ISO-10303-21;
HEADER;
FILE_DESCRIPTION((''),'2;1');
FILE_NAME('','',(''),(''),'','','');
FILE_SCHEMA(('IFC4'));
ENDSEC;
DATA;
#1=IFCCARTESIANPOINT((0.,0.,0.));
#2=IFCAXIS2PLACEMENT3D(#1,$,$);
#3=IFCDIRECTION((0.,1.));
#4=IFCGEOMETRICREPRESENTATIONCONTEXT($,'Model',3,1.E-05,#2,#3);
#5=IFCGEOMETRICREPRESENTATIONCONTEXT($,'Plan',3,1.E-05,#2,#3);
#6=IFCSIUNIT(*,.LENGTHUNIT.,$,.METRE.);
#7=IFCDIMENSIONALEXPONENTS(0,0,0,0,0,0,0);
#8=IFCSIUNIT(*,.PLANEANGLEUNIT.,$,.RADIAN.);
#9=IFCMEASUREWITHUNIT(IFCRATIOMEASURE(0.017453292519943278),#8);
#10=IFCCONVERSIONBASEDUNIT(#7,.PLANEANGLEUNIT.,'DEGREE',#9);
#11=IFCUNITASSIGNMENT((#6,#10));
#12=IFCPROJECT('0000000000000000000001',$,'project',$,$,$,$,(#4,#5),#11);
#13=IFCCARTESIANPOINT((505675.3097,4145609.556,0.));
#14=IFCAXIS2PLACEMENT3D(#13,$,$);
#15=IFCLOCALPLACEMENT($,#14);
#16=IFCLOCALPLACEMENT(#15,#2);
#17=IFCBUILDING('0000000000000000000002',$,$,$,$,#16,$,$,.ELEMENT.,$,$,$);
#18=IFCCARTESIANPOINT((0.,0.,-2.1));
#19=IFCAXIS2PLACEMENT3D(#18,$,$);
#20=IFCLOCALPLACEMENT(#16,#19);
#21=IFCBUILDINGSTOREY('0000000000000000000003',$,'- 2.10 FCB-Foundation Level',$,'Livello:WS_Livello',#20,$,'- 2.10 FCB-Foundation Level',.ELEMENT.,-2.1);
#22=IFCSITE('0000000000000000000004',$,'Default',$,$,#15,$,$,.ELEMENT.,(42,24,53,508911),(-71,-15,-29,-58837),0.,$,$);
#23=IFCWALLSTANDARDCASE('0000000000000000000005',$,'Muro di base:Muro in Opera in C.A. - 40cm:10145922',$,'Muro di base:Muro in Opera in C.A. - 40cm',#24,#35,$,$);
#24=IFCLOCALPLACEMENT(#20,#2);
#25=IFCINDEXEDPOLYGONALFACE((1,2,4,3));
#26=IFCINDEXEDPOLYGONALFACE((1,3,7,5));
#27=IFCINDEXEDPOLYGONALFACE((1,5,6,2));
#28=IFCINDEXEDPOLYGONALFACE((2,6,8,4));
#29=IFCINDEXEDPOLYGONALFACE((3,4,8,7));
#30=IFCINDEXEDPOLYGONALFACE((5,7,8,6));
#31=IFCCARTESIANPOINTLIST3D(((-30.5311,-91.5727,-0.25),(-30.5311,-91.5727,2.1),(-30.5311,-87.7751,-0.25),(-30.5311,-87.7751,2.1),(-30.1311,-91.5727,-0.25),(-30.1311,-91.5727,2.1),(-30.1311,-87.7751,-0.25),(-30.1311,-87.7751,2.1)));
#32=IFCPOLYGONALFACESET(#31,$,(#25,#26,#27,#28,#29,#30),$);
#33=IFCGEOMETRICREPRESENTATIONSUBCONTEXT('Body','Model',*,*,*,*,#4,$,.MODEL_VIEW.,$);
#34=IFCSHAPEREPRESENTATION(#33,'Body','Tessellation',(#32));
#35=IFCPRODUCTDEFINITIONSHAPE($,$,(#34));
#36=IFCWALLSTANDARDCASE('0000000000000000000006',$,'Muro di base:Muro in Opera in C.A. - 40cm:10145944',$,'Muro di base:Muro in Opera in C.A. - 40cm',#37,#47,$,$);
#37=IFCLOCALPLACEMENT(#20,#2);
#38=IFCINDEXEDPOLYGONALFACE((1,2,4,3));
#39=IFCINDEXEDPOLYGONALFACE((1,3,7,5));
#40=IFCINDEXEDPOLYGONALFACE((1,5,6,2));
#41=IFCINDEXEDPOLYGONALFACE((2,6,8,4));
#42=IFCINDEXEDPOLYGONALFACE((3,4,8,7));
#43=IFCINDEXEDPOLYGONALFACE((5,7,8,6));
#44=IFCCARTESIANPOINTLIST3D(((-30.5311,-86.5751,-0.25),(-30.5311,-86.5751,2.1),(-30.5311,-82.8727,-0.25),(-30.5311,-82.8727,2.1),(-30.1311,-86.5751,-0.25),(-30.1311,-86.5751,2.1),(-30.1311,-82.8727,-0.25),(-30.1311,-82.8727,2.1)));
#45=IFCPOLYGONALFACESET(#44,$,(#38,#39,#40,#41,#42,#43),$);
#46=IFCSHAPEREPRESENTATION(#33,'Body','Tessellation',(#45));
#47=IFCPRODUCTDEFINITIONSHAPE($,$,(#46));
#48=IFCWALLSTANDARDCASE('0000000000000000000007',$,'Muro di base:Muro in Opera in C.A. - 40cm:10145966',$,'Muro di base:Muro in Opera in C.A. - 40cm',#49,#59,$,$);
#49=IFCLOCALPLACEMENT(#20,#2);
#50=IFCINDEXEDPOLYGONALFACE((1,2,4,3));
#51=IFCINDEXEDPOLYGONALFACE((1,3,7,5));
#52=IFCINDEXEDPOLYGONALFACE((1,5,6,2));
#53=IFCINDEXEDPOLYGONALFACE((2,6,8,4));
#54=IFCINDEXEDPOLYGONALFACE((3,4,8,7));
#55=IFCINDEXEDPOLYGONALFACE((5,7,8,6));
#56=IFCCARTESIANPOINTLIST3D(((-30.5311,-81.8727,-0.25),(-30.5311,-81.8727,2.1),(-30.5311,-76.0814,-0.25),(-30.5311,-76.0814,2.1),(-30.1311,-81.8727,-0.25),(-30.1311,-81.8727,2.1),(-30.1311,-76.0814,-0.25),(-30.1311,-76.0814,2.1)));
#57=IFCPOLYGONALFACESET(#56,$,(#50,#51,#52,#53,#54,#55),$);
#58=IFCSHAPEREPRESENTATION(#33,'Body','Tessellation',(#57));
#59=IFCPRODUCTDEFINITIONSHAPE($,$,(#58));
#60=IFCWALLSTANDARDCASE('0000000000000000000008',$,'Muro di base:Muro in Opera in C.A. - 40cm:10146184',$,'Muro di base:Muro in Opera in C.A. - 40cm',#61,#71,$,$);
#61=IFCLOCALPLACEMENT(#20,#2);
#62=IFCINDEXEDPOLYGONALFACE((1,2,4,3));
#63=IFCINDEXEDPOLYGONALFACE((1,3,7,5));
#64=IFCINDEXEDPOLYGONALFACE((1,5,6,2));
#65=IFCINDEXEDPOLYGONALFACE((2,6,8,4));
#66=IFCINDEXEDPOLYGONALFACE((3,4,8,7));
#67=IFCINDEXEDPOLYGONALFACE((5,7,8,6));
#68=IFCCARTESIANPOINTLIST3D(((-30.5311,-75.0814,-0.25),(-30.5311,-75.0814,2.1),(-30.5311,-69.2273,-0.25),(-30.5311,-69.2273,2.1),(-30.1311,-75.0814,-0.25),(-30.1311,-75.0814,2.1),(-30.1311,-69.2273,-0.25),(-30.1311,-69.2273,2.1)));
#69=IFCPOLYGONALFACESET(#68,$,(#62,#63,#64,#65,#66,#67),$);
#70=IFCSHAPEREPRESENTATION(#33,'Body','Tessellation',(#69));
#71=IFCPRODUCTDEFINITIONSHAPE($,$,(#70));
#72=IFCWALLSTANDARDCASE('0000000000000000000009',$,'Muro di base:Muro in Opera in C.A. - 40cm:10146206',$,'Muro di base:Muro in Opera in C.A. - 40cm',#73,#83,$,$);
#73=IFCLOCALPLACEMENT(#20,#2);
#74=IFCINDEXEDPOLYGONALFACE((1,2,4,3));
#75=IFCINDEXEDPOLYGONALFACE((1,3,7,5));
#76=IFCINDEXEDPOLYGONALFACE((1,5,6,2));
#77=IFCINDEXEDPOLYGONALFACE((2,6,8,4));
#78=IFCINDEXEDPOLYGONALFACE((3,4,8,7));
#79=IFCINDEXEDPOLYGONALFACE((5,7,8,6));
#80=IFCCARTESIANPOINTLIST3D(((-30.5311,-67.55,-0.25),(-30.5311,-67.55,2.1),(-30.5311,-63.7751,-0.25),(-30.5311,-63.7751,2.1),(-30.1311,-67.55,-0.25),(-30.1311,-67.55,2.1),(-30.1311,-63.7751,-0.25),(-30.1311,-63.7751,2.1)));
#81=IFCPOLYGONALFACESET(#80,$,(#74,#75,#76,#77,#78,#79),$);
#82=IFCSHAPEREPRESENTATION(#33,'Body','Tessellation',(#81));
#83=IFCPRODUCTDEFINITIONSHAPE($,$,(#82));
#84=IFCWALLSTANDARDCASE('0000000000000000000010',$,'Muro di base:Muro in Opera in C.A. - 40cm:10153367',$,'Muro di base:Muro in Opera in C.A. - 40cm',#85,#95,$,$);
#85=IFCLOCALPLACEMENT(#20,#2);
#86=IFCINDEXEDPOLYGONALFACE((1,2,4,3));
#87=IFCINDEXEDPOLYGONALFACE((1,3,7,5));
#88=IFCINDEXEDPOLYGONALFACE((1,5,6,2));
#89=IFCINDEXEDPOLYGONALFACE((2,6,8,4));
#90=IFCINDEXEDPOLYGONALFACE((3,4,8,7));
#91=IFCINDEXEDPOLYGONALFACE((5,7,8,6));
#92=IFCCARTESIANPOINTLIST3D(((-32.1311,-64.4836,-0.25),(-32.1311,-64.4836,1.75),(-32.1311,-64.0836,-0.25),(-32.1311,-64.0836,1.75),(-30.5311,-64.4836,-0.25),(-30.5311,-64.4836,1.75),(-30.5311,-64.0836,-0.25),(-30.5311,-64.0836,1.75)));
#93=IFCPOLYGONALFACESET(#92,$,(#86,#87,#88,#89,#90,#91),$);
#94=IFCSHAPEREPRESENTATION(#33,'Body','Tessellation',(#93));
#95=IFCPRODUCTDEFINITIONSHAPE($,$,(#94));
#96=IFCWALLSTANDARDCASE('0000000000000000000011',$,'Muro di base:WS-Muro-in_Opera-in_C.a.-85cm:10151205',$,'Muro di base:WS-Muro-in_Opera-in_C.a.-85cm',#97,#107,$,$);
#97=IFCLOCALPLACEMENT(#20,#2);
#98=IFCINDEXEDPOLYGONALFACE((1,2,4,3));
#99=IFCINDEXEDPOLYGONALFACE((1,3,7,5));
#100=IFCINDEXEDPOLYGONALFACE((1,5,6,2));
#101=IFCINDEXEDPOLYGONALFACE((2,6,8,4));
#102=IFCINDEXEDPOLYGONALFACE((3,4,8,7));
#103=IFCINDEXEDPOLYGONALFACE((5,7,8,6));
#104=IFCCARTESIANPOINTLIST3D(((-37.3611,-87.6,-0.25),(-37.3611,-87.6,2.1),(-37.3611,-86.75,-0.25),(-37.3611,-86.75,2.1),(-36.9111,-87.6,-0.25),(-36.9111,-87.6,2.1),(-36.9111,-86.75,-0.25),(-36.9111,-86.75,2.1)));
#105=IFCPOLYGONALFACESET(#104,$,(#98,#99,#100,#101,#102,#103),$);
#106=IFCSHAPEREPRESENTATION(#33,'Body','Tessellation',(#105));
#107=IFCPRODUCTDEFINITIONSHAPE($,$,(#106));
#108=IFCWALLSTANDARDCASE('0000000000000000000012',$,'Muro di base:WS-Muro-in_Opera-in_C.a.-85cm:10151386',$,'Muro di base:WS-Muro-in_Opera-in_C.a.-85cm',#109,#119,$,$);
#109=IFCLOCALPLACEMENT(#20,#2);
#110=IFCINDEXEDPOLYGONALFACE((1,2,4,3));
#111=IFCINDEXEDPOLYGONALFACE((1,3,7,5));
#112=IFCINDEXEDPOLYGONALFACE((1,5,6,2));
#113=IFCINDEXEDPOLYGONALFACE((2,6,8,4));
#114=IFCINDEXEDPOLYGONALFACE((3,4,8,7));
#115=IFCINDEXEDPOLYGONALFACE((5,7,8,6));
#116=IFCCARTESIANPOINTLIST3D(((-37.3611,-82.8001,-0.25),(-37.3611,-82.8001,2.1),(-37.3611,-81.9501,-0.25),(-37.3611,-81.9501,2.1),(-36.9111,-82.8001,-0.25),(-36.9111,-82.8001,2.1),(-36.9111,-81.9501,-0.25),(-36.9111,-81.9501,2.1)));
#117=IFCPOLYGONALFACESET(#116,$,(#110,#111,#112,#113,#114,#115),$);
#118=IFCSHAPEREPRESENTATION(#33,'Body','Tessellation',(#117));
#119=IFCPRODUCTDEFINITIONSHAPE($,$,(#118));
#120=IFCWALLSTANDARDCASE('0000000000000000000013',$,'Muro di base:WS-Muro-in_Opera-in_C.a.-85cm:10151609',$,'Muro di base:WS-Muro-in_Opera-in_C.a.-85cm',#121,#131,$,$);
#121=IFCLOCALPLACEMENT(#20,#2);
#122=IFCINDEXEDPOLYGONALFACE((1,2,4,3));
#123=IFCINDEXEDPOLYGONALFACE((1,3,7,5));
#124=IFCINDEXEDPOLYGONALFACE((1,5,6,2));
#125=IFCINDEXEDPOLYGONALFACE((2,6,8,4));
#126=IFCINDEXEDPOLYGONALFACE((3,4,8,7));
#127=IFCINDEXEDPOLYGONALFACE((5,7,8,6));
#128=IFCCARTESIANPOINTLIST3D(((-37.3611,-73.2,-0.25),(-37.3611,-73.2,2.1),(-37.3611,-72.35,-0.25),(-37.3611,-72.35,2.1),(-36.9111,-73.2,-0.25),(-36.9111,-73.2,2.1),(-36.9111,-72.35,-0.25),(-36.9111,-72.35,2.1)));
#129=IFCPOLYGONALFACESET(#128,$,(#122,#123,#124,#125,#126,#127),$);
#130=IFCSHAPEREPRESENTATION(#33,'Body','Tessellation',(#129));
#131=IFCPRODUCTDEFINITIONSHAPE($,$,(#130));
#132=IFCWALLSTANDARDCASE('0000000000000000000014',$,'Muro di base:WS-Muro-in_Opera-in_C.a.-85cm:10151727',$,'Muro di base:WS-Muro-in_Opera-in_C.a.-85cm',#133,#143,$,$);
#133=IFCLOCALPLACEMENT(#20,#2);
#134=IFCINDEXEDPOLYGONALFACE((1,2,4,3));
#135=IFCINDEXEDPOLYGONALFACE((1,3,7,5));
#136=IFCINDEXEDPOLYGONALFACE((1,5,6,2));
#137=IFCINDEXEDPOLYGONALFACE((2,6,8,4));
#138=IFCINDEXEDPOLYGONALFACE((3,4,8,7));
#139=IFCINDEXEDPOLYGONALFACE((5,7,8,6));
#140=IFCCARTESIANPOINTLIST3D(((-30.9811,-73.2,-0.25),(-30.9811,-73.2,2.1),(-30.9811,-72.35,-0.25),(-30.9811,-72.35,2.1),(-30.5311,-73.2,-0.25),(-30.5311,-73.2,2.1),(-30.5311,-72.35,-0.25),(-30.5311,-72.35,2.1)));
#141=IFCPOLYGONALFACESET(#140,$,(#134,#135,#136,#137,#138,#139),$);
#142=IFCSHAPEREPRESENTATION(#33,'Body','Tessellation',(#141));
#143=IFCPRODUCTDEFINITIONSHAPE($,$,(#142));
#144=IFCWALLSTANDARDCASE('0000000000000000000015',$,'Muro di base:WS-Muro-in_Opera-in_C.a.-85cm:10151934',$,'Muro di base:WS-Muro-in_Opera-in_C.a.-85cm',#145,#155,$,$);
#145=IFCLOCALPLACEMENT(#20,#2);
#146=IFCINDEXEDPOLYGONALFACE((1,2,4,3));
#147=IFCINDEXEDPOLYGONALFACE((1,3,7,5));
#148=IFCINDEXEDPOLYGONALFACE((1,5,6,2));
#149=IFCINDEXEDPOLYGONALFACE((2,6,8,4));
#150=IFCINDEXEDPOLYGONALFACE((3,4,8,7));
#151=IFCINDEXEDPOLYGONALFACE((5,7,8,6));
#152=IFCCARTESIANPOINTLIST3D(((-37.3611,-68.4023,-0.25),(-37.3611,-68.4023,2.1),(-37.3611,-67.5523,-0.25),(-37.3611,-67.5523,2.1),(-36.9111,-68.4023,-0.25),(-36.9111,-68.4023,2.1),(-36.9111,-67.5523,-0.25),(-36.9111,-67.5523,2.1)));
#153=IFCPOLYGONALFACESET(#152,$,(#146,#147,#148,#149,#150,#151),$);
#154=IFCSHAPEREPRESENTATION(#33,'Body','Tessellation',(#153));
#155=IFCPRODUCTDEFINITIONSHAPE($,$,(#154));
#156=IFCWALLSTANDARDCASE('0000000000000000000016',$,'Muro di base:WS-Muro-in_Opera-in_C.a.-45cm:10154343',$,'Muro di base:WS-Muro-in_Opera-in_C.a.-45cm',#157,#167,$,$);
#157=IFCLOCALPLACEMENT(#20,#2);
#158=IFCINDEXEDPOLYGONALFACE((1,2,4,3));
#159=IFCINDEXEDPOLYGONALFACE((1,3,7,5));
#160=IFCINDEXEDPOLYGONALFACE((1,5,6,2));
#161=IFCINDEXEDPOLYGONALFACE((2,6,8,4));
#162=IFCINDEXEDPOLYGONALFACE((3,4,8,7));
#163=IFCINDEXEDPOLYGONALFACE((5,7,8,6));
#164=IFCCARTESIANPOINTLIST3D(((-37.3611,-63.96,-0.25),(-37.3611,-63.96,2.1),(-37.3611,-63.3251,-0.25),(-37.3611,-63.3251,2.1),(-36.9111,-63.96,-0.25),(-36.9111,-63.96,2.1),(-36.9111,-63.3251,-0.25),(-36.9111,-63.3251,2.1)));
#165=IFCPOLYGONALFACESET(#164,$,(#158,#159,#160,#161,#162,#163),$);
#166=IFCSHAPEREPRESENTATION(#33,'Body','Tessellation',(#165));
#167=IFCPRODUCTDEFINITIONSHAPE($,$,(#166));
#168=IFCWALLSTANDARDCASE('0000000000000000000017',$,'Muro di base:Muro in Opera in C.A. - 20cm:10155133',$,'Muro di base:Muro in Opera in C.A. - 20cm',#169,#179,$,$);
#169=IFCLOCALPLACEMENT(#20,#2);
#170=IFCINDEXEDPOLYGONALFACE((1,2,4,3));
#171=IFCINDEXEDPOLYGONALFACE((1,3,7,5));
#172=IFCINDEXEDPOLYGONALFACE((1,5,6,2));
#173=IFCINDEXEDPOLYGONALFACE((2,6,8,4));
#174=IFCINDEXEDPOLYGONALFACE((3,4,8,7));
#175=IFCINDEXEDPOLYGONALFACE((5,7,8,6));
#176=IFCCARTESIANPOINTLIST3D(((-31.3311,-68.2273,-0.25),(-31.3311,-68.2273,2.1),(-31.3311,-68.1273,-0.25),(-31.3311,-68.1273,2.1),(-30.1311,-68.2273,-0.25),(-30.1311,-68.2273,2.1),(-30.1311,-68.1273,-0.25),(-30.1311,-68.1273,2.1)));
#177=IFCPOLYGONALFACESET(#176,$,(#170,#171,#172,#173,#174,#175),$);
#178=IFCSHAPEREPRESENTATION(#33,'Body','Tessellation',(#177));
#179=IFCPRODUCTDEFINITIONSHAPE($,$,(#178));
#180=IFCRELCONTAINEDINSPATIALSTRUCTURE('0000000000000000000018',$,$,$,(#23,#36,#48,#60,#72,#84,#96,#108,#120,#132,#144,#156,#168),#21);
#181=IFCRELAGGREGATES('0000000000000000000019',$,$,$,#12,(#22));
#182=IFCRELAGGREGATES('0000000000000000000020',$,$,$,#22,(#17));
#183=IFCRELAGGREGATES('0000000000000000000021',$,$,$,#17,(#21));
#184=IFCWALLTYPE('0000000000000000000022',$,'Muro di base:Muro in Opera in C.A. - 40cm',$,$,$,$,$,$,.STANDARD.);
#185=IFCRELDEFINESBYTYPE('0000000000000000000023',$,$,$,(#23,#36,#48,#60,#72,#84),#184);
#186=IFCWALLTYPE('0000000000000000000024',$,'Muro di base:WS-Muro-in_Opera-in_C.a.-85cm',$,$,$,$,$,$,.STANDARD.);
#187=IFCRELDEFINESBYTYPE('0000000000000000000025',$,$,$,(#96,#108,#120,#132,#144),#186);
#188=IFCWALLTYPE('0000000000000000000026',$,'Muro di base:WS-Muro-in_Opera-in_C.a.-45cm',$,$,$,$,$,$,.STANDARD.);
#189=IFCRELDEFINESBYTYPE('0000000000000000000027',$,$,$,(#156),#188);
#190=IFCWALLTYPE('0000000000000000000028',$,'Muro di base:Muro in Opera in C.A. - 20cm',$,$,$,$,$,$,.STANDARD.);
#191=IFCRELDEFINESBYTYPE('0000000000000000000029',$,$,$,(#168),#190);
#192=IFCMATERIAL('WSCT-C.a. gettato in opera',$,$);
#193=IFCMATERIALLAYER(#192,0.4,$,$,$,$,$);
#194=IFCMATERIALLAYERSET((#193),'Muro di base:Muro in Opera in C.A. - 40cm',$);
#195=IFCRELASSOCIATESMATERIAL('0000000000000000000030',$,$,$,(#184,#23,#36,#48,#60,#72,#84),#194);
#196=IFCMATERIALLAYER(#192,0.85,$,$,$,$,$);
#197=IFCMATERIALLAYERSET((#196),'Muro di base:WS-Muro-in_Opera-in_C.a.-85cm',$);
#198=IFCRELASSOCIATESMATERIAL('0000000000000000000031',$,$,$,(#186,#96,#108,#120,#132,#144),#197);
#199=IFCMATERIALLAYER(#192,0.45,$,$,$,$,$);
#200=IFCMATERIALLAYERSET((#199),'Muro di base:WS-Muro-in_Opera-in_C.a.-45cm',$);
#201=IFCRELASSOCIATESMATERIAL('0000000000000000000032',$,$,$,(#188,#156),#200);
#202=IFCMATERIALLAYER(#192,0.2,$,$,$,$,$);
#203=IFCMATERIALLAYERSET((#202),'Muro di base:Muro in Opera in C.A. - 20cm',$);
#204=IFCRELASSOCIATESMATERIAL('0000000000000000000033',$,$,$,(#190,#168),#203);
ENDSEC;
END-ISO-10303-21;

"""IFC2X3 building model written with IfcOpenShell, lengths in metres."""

from ifc_helpers import new_model, entity, si_unit, converted_unit, direction, frame, frame_2d, origin, place, context, subcontext, project, spatial, polyline, rectangle, extrude, clip, bounded_halfspace, material, layer, layer_set, layer_usage, type_object, element, save


model = new_model("IFC2X3")

# Units and contexts
model_context = context("Model", 3, precision=1e-05, world=origin(), true_north=direction((0.0, 1.0)))
plan_context = context("Plan", 3, precision=1e-05, world=origin(), true_north=direction((0.0, 1.0)))
body_context = subcontext(model_context, "Body", "Model", "MODEL_VIEW")
ifc_project = project(units=[si_unit("LENGTHUNIT", "METRE"), converted_unit("PLANEANGLEUNIT", "DEGREE", entity("IfcRatioMeasure", 0.017453292519943278), si_unit("PLANEANGLEUNIT", "RADIAN"), dimensions=[0, 0, 0, 0, 0, 0, 0])], contexts=[model_context, plan_context])

# Site, building, storey
site_placement = place(None, frame((505675.3097, 4145609.556, 0.0)))
site = spatial("IfcSite", under=ifc_project, at=site_placement, Name="Default", CompositionType="ELEMENT", RefLatitude=(42, 24, 53, 508911), RefLongitude=(-71, -15, -29, -58837), RefElevation=0.0)
building_placement = place(site_placement, origin())
building = spatial("IfcBuilding", under=site, at=building_placement, CompositionType="ELEMENT")
storey_placement = place(building_placement, frame((0.0, 0.0, -2.1)))
storey = spatial("IfcBuildingStorey", under=building, at=storey_placement, Name="- 2.10 FCB-Foundation Level", ObjectType="Livello:WS_Livello", LongName="- 2.10 FCB-Foundation Level", CompositionType="ELEMENT", Elevation=-2.1)

# Shared definitions
ifc_material = material(Name="WSCT-C.a. gettato in opera")

# Walls
ifc_layer_1 = layer(ifc_material, 0.4)
ifc_layer_set_1 = layer_set([ifc_layer_1], Name="Muro di base:Muro in Opera in C.A. - 40cm")
ifc_layer_usage_1 = layer_usage(ifc_layer_set_1, "AXIS2", "NEGATIVE", 0.2)
wall_type_1 = type_object("IfcWallType", Name="Muro di base:Muro in Opera in C.A. - 40cm", PredefinedType="STANDARD", material=ifc_layer_set_1)
wall_1_placement = place(storey_placement, frame((-30.3311, -91.5727, -0.25), z_axis=(0.0, 0.0, 1.0), x_axis=(0.0, 1.0, 0.0)))
element("IfcWallStandardCase", 1, at=wall_1_placement, inside=storey, type_object=wall_type_1, material=ifc_layer_usage_1, Name="Muro di base:Muro in Opera in C.A. - 40cm:10145922", ObjectType="Muro di base:Muro in Opera in C.A. - 40cm", context=body_context, shape_type="SweptSolid", body=[
    extrude(rectangle(XDim=3.7976, YDim=0.4, at=frame_2d((1.8988, 0.0), x_axis=(-1.0, 0.0))), origin(), (0.0, 0.0, 1.0), 2.35),
])
wall_2_placement = place(storey_placement, frame((-30.3311, -86.5751, -0.25), z_axis=(0.0, 0.0, 1.0), x_axis=(0.0, 1.0, 0.0)))
element("IfcWallStandardCase", 2, at=wall_2_placement, inside=storey, type_object=wall_type_1, material=ifc_layer_usage_1, Name="Muro di base:Muro in Opera in C.A. - 40cm:10145944", ObjectType="Muro di base:Muro in Opera in C.A. - 40cm", context=body_context, shape_type="SweptSolid", body=[
    extrude(rectangle(XDim=3.7024, YDim=0.4, at=frame_2d((1.8512, 0.0), x_axis=(-1.0, 0.0))), origin(), (0.0, 0.0, 1.0), 2.35),
])
wall_3_placement = place(storey_placement, frame((-30.3311, -81.8727, -0.25), z_axis=(0.0, 0.0, 1.0), x_axis=(0.0, 1.0, 0.0)))
element("IfcWallStandardCase", 3, at=wall_3_placement, inside=storey, type_object=wall_type_1, material=ifc_layer_usage_1, Name="Muro di base:Muro in Opera in C.A. - 40cm:10145966", ObjectType="Muro di base:Muro in Opera in C.A. - 40cm", context=body_context, shape_type="SweptSolid", body=[
    extrude(rectangle(XDim=5.7914, YDim=0.4, at=frame_2d((2.8957, 0.0), x_axis=(-1.0, 0.0))), origin(), (0.0, 0.0, 1.0), 2.35),
])
wall_4_placement = place(storey_placement, frame((-30.3311, -75.0814, -0.25), z_axis=(0.0, 0.0, 1.0), x_axis=(0.0, 1.0, 0.0)))
element("IfcWallStandardCase", 4, at=wall_4_placement, inside=storey, type_object=wall_type_1, material=ifc_layer_usage_1, Name="Muro di base:Muro in Opera in C.A. - 40cm:10146184", ObjectType="Muro di base:Muro in Opera in C.A. - 40cm", context=body_context, shape_type="SweptSolid", body=[
    extrude(rectangle(XDim=5.854, YDim=0.4, at=frame_2d((2.927, 0.0), x_axis=(-1.0, 0.0))), origin(), (0.0, 0.0, 1.0), 2.35),
])
wall_5_placement = place(storey_placement, frame((-30.3311, -67.55, -0.25), z_axis=(0.0, 0.0, 1.0), x_axis=(0.0, 1.0, 0.0)))
element("IfcWallStandardCase", 5, at=wall_5_placement, inside=storey, type_object=wall_type_1, material=ifc_layer_usage_1, Name="Muro di base:Muro in Opera in C.A. - 40cm:10146206", ObjectType="Muro di base:Muro in Opera in C.A. - 40cm", context=body_context, shape_type="SweptSolid", body=[
    extrude(rectangle(XDim=3.7749, YDim=0.4, at=frame_2d((1.8874, 0.0), x_axis=(-1.0, 0.0))), origin(), (0.0, 0.0, 1.0), 2.35),
])
wall_6_placement = place(storey_placement, frame((-32.1311, -64.2836, -0.25)))
element("IfcWallStandardCase", 6, at=wall_6_placement, inside=storey, type_object=wall_type_1, material=ifc_layer_usage_1, Name="Muro di base:Muro in Opera in C.A. - 40cm:10153367", ObjectType="Muro di base:Muro in Opera in C.A. - 40cm", context=body_context, shape_type="SweptSolid", body=[
    extrude(rectangle(XDim=1.6001, YDim=0.4, at=frame_2d((0.8, 0.0), x_axis=(-1.0, 0.0))), origin(), (0.0, 0.0, 1.0), 2.0),
])
ifc_layer_2 = layer(ifc_material, 0.85)
ifc_layer_set_2 = layer_set([ifc_layer_2], Name="Muro di base:WS-Muro-in_Opera-in_C.a.-85cm")
ifc_layer_usage_2 = layer_usage(ifc_layer_set_2, "AXIS2", "NEGATIVE", 0.425)
wall_type_2 = type_object("IfcWallType", Name="Muro di base:WS-Muro-in_Opera-in_C.a.-85cm", PredefinedType="STANDARD", material=ifc_layer_set_2)
wall_7_placement = place(storey_placement, frame((-37.3611, -87.175, -0.25)))
element("IfcWallStandardCase", 7, at=wall_7_placement, inside=storey, type_object=wall_type_2, material=ifc_layer_usage_2, Name="Muro di base:WS-Muro-in_Opera-in_C.a.-85cm:10151205", ObjectType="Muro di base:WS-Muro-in_Opera-in_C.a.-85cm", context=body_context, shape_type="SweptSolid", body=[
    extrude(rectangle(XDim=0.45, YDim=0.85, at=frame_2d((0.225, 0.0), x_axis=(-1.0, 0.0))), origin(), (0.0, 0.0, 1.0), 2.35),
])
wall_8_placement = place(storey_placement, frame((-37.3611, -82.3751, -0.25)))
element("IfcWallStandardCase", 8, at=wall_8_placement, inside=storey, type_object=wall_type_2, material=ifc_layer_usage_2, Name="Muro di base:WS-Muro-in_Opera-in_C.a.-85cm:10151386", ObjectType="Muro di base:WS-Muro-in_Opera-in_C.a.-85cm", context=body_context, shape_type="SweptSolid", body=[
    extrude(rectangle(XDim=0.45, YDim=0.85, at=frame_2d((0.225, 0.0), x_axis=(-1.0, 0.0))), origin(), (0.0, 0.0, 1.0), 2.35),
])
wall_9_placement = place(storey_placement, frame((-37.3611, -72.775, -0.25)))
element("IfcWallStandardCase", 9, at=wall_9_placement, inside=storey, type_object=wall_type_2, material=ifc_layer_usage_2, Name="Muro di base:WS-Muro-in_Opera-in_C.a.-85cm:10151609", ObjectType="Muro di base:WS-Muro-in_Opera-in_C.a.-85cm", context=body_context, shape_type="SweptSolid", body=[
    extrude(rectangle(XDim=0.45, YDim=0.85, at=frame_2d((0.225, 0.0), x_axis=(-1.0, 0.0))), origin(), (0.0, 0.0, 1.0), 2.35),
])
wall_10_placement = place(storey_placement, frame((-30.9811, -72.775, -0.25)))
element("IfcWallStandardCase", 10, at=wall_10_placement, inside=storey, type_object=wall_type_2, material=ifc_layer_usage_2, Name="Muro di base:WS-Muro-in_Opera-in_C.a.-85cm:10151727", ObjectType="Muro di base:WS-Muro-in_Opera-in_C.a.-85cm", context=body_context, shape_type="SweptSolid", body=[
    extrude(rectangle(XDim=0.45, YDim=0.85, at=frame_2d((0.225, 0.0), x_axis=(-1.0, 0.0))), origin(), (0.0, 0.0, 1.0), 2.35),
])
wall_11_placement = place(storey_placement, frame((-37.3611, -67.9773, -0.25)))
element("IfcWallStandardCase", 11, at=wall_11_placement, inside=storey, type_object=wall_type_2, material=ifc_layer_usage_2, Name="Muro di base:WS-Muro-in_Opera-in_C.a.-85cm:10151934", ObjectType="Muro di base:WS-Muro-in_Opera-in_C.a.-85cm", context=body_context, shape_type="SweptSolid", body=[
    extrude(rectangle(XDim=0.45, YDim=0.85, at=frame_2d((0.225, 0.0), x_axis=(-1.0, 0.0))), origin(), (0.0, 0.0, 1.0), 2.35),
])
ifc_layer_3 = layer(ifc_material, 0.45)
ifc_layer_set_3 = layer_set([ifc_layer_3], Name="Muro di base:WS-Muro-in_Opera-in_C.a.-45cm")
ifc_layer_usage_3 = layer_usage(ifc_layer_set_3, "AXIS2", "NEGATIVE", 0.225)
wall_type_3 = type_object("IfcWallType", Name="Muro di base:WS-Muro-in_Opera-in_C.a.-45cm", PredefinedType="STANDARD", material=ifc_layer_set_3)
wall_12_placement = place(storey_placement, frame((-37.1361, -63.3251, -0.25), z_axis=(0.0, 0.0, 1.0), x_axis=(0.0, -1.0, 0.0)))
element("IfcWallStandardCase", 12, at=wall_12_placement, inside=storey, type_object=wall_type_3, material=ifc_layer_usage_3, Name="Muro di base:WS-Muro-in_Opera-in_C.a.-45cm:10154343", ObjectType="Muro di base:WS-Muro-in_Opera-in_C.a.-45cm", context=body_context, shape_type="SweptSolid", body=[
    extrude(rectangle(XDim=0.635, YDim=0.45, at=frame_2d((0.3175, 0.0), x_axis=(-1.0, 0.0))), origin(), (0.0, 0.0, 1.0), 2.35),
])
ifc_layer_4 = layer(ifc_material, 0.2)
ifc_layer_set_4 = layer_set([ifc_layer_4], Name="Muro di base:Muro in Opera in C.A. - 20cm")
ifc_layer_usage_4 = layer_usage(ifc_layer_set_4, "AXIS2", "NEGATIVE", 0.1)
wall_type_4 = type_object("IfcWallType", Name="Muro di base:Muro in Opera in C.A. - 20cm", PredefinedType="STANDARD", material=ifc_layer_set_4)
wall_13_placement = place(storey_placement, frame((-31.3311, -68.1273, -0.25)))
element("IfcWallStandardCase", 13, at=wall_13_placement, inside=storey, type_object=wall_type_4, material=ifc_layer_usage_4, Name="Muro di base:Muro in Opera in C.A. - 20cm:10155133", ObjectType="Muro di base:Muro in Opera in C.A. - 20cm", context=body_context, shape_type="Clipping", body=[
    clip(extrude(rectangle(XDim=1.2, YDim=0.2, at=frame_2d((0.6, 0.0), x_axis=(-1.0, 0.0))), origin(), (0.0, 0.0, 1.0), 2.35), bounded_halfspace(frame((1.2, 0.0, 0.0), z_axis=(0.0, -1.0, 0.0), x_axis=(1.0, 0.0, 0.0)), True, frame((1.2, 0.0, 0.0), z_axis=(0.0, -1.0, 0.0), x_axis=(1.0, 0.0, 0.0)), polyline([(0.0, 0.0), (0.0, 2.35), (-1.2, 2.35), (-1.2, 0.0), (0.0, 0.0)]))),
])

save(model, "model.ifc")
